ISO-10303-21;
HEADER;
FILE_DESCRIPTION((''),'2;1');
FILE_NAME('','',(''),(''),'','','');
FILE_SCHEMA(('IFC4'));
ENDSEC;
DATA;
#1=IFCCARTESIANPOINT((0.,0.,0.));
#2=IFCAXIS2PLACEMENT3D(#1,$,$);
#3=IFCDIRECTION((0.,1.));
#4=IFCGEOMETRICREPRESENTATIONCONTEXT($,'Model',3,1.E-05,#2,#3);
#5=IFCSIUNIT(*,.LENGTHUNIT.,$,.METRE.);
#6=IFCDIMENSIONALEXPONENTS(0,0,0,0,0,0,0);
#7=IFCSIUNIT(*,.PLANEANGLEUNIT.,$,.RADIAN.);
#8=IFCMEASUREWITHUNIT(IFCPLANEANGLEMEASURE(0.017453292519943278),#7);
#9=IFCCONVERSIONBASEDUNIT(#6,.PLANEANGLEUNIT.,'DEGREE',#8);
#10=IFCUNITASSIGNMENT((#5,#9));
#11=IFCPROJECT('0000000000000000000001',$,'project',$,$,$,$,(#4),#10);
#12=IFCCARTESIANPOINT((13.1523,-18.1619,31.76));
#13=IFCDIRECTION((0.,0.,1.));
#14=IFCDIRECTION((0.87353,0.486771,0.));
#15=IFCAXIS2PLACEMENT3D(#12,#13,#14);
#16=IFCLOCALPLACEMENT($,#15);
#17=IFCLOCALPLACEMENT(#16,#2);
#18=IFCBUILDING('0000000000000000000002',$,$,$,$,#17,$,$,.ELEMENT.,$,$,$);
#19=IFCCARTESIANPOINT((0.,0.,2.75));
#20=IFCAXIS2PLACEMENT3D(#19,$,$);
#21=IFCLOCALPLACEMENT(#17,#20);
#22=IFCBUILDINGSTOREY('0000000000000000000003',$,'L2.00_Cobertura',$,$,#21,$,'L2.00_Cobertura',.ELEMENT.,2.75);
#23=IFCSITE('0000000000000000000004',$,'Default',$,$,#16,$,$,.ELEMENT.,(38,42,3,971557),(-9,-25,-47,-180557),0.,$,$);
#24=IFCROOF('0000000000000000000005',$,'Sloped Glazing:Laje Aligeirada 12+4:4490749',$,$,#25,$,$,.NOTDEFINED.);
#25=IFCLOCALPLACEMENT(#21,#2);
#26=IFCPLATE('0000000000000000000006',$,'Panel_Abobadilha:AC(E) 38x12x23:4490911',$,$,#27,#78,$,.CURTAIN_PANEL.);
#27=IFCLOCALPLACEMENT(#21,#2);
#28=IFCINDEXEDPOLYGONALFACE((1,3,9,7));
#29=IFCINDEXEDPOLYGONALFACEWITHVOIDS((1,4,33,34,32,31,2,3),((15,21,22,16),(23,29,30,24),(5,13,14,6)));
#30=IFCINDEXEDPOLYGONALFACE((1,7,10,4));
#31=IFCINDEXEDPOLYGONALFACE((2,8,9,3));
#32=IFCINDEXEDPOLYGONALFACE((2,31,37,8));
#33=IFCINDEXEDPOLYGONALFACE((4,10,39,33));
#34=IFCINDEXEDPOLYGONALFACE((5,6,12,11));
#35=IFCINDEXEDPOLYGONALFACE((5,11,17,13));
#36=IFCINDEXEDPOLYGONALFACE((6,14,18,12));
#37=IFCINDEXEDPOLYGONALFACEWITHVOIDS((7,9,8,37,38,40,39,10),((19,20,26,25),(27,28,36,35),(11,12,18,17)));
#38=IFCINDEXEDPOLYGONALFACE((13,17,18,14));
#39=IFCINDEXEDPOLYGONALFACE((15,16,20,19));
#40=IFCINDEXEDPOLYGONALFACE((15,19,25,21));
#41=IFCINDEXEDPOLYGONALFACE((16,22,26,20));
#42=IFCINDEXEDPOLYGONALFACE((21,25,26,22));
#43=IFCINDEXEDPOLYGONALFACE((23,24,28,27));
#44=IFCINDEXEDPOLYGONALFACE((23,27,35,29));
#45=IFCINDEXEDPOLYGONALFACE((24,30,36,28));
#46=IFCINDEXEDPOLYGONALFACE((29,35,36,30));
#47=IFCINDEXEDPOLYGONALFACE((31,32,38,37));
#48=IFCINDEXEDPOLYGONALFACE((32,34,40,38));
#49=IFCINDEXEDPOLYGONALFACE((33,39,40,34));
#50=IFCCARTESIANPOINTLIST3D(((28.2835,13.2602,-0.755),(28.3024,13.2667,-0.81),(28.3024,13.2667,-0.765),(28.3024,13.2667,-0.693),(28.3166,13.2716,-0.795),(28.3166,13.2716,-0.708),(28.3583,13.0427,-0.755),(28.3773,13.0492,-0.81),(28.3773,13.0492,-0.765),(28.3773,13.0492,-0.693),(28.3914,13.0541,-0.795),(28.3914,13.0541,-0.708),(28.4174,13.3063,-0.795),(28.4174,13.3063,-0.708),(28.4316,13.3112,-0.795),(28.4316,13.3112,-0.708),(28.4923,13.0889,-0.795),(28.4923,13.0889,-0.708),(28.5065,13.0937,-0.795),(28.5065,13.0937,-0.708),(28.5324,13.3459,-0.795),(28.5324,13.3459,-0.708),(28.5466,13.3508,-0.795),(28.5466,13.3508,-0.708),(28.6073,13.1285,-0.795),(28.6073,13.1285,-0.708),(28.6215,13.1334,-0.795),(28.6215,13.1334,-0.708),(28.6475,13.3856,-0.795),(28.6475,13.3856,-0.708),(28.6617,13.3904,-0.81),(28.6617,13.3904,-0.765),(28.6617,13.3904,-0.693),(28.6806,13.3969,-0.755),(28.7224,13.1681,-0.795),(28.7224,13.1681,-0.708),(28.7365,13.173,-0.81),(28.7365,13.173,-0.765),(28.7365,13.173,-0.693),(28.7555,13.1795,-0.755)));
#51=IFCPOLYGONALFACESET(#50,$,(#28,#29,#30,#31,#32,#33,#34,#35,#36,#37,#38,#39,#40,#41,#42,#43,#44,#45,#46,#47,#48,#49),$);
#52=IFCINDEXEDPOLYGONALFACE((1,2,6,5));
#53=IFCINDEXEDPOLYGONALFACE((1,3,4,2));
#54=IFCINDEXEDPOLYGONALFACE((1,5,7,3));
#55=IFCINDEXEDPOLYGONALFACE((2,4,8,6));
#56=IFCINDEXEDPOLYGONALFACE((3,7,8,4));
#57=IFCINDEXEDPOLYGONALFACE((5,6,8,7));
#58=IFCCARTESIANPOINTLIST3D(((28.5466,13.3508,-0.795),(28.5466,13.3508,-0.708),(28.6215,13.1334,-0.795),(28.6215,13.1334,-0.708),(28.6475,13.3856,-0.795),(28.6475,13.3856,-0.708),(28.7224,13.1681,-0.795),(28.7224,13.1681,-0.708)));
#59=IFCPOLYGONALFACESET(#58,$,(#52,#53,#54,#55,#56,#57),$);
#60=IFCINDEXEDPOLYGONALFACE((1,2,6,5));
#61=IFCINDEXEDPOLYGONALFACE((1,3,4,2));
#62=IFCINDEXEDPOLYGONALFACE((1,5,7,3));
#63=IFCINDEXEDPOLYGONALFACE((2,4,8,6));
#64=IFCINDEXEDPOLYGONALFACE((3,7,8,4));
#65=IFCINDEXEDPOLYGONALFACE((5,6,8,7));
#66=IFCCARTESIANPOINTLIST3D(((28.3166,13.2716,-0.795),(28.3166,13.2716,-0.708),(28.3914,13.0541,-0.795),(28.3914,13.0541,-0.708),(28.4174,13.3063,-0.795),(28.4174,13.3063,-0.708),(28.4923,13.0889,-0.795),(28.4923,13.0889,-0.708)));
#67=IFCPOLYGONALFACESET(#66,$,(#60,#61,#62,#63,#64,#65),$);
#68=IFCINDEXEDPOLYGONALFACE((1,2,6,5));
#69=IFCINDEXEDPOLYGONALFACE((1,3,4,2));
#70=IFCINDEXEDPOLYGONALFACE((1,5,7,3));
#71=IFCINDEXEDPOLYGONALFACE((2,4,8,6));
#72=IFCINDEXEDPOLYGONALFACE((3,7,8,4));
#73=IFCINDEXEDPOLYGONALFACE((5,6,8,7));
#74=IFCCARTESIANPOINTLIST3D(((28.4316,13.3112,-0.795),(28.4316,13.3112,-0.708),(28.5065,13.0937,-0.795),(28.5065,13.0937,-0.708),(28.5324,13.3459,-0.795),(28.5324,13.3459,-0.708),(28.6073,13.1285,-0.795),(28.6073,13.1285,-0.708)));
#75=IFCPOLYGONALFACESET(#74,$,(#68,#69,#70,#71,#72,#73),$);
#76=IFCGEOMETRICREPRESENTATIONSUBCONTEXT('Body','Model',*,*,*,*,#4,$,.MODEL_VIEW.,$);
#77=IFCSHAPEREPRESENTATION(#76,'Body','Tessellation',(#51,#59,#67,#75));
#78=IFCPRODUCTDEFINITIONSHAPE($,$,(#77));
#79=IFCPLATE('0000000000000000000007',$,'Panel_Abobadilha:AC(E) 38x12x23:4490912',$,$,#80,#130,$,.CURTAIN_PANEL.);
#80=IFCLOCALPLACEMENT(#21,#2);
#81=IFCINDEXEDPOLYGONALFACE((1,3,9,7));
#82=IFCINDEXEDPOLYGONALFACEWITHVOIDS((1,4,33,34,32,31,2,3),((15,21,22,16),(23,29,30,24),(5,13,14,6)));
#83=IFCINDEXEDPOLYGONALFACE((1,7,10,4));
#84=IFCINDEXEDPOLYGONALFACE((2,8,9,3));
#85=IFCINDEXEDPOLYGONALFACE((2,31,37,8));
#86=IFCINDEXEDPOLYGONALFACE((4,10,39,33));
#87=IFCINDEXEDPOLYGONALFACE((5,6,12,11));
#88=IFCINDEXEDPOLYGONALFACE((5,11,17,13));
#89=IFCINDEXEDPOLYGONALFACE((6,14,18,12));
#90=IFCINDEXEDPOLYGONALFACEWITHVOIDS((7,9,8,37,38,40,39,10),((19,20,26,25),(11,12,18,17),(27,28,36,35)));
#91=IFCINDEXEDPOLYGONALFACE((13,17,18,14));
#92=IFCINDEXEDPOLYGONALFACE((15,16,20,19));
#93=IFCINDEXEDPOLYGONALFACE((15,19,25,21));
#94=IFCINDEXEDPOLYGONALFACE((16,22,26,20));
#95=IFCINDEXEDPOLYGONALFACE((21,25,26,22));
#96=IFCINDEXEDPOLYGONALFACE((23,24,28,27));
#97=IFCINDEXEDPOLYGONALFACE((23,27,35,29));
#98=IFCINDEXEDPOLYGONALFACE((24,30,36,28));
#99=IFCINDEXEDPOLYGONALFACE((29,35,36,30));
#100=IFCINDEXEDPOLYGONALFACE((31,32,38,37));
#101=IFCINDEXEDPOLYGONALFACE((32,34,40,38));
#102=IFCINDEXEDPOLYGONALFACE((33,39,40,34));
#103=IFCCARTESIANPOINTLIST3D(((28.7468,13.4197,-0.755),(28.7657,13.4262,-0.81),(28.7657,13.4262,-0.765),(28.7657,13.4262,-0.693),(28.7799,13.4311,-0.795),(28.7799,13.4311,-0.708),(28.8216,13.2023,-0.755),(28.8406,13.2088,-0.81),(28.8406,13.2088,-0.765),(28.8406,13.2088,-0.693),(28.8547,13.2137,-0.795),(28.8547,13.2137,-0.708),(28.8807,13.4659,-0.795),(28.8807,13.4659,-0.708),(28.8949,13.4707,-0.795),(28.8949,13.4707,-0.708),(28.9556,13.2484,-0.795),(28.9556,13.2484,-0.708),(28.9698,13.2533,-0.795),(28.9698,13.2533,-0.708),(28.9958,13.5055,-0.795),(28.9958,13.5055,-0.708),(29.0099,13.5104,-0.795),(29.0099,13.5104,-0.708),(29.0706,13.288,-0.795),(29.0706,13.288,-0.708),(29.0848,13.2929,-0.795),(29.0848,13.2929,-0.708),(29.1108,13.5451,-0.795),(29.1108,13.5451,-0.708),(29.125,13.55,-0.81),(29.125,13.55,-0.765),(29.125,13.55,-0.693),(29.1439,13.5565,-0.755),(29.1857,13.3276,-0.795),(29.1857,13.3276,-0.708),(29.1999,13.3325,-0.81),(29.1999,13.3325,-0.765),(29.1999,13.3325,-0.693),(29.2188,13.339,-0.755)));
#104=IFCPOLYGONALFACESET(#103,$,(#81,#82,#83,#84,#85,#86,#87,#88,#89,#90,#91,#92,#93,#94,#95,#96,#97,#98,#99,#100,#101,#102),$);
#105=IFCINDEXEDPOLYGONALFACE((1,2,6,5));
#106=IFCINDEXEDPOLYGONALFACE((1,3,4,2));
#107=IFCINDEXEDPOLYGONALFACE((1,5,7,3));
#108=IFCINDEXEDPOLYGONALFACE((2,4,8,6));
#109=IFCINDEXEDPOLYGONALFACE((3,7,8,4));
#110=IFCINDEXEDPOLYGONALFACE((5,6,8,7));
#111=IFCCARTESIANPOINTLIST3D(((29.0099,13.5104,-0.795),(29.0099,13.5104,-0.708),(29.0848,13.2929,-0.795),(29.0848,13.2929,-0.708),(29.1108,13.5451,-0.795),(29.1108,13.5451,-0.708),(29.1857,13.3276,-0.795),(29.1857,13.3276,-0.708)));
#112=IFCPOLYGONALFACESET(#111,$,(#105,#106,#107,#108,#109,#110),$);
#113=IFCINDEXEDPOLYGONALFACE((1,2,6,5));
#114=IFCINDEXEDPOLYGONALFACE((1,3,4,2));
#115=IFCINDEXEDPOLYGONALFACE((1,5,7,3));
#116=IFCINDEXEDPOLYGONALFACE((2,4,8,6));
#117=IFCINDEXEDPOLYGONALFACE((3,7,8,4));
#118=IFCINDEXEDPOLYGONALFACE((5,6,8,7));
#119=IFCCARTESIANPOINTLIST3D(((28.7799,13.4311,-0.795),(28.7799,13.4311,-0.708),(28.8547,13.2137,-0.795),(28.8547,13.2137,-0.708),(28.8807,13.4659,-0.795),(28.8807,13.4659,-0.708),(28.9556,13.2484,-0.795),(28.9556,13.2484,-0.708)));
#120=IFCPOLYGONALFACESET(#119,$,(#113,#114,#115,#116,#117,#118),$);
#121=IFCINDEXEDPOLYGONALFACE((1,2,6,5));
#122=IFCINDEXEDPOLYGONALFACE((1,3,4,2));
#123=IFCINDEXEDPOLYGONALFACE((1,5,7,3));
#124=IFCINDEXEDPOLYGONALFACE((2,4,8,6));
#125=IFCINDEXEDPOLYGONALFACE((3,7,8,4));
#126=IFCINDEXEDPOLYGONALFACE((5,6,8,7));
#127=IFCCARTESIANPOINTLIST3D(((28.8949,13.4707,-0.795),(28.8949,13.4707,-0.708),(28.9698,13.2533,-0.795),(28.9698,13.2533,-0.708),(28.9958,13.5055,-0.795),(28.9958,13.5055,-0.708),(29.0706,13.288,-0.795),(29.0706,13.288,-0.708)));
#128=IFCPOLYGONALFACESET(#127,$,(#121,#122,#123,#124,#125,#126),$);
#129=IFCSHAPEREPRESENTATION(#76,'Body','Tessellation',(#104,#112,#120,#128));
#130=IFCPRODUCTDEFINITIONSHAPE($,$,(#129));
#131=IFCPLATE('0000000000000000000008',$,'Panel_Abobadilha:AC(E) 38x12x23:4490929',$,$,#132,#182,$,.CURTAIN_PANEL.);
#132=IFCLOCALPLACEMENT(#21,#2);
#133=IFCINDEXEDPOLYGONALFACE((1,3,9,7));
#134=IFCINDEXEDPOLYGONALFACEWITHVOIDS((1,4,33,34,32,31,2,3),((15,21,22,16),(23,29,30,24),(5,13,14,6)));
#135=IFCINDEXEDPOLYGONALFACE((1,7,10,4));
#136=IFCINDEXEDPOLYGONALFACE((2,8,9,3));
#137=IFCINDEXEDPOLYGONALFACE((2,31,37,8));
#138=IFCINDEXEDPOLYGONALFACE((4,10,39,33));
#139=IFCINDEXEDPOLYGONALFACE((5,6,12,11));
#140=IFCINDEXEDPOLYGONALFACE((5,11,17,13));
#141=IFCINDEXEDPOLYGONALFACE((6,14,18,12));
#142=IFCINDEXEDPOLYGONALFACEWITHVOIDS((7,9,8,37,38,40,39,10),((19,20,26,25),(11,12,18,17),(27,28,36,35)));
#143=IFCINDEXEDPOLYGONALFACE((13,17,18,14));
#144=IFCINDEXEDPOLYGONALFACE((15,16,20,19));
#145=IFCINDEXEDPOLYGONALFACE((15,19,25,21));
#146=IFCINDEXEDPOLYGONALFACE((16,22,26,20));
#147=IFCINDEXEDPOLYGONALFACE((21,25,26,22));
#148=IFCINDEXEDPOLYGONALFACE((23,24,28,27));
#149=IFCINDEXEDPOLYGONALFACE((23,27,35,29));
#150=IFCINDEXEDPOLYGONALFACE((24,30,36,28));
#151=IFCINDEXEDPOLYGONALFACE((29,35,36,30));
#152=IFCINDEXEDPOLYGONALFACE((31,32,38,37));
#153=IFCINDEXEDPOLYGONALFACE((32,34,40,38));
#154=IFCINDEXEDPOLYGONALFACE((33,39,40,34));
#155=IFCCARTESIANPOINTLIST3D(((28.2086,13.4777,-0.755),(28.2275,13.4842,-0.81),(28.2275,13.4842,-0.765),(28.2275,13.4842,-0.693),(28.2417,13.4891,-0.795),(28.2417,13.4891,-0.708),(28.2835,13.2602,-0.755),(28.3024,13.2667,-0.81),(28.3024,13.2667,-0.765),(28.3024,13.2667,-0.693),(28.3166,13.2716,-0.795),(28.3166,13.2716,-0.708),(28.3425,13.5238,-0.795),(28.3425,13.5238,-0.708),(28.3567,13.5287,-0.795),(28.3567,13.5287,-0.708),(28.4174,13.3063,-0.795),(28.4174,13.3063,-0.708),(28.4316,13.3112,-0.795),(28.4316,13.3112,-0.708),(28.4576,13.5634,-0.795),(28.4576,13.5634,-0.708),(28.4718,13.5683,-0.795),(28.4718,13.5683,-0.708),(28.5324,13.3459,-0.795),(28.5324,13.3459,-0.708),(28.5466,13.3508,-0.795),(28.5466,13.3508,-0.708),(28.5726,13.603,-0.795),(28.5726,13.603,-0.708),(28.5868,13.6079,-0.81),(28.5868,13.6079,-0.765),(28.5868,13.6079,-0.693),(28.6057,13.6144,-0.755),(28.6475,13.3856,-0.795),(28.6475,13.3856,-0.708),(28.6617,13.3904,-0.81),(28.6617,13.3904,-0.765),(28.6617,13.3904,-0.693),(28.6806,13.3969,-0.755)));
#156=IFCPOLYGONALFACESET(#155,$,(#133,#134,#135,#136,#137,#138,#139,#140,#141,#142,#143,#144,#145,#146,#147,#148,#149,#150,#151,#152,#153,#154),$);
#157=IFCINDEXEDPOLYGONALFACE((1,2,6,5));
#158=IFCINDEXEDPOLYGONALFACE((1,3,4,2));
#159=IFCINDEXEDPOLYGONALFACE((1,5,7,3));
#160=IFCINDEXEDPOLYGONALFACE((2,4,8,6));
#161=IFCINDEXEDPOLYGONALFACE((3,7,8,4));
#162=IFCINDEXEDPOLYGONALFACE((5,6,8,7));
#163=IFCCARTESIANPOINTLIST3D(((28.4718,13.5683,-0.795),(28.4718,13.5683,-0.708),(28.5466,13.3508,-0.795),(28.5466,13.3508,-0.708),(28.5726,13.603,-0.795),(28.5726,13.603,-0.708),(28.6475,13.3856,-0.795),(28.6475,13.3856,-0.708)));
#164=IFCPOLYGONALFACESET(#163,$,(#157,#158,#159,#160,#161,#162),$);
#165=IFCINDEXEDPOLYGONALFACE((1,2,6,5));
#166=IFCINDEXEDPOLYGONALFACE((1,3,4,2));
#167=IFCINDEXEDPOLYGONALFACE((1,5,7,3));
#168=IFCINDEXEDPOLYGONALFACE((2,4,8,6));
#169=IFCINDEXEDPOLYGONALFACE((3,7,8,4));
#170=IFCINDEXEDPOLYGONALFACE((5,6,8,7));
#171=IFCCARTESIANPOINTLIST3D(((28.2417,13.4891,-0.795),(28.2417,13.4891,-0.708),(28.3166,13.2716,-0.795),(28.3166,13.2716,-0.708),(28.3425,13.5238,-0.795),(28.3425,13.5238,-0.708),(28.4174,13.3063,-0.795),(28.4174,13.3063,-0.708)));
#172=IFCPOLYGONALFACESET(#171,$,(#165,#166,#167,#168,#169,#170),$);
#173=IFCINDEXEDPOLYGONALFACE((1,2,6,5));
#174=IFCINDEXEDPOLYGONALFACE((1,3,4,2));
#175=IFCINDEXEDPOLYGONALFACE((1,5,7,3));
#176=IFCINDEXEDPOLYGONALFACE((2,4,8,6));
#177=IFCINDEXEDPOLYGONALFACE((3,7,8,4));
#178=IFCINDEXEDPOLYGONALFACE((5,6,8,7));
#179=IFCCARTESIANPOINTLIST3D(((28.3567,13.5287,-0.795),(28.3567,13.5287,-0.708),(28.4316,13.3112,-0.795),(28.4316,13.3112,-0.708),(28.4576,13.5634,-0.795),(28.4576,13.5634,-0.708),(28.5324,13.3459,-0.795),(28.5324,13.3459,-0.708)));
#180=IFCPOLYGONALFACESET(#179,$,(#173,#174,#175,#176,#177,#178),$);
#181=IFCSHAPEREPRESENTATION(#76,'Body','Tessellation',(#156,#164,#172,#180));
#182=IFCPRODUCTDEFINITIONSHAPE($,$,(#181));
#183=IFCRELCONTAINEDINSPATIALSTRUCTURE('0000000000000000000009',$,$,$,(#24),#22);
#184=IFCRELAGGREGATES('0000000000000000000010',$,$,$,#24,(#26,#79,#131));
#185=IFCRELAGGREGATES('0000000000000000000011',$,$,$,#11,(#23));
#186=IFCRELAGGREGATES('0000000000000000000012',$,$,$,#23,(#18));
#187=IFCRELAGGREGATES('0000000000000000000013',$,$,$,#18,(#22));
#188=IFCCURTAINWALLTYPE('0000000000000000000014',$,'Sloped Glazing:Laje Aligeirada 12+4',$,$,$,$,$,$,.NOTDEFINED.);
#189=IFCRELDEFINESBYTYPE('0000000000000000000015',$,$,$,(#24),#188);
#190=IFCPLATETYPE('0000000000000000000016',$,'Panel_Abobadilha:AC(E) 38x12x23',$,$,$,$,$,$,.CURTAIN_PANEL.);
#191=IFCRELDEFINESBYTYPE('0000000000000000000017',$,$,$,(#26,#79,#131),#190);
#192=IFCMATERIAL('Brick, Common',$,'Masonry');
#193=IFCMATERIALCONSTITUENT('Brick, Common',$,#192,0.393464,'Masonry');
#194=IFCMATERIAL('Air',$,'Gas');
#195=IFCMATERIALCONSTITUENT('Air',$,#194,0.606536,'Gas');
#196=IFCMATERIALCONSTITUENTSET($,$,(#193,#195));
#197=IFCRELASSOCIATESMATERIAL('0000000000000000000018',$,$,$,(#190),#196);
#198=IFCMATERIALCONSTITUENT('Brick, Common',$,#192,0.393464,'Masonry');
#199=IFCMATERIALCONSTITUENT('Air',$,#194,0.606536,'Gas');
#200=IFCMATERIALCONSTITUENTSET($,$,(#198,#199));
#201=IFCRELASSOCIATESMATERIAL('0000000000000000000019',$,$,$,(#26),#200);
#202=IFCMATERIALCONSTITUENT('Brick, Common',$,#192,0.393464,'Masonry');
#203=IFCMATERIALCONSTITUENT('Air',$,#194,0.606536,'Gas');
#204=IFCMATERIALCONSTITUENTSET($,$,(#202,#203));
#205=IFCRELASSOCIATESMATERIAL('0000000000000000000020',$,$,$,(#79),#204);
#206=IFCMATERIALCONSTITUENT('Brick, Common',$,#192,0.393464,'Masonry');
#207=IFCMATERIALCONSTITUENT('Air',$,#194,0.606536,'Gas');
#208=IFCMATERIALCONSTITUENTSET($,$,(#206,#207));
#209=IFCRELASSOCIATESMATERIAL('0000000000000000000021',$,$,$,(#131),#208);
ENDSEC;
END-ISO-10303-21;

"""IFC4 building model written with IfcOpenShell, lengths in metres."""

from ifc_helpers import new_model, entity, si_unit, converted_unit, direction, frame, origin, place, context, subcontext, project, spatial, indexed_curve, outline, extrude, source, transform, mapped, material, constituent, constituent_set, type_object, type_shapes, element, aggregate, save


model = new_model("IFC4")

# Units and contexts
model_context = context("Model", 3, precision=1e-05, world=origin(), true_north=direction((0.0, 1.0)))
body_context = subcontext(model_context, "Body", "Model", "MODEL_VIEW")
ifc_project = project(units=[si_unit("LENGTHUNIT", "METRE"), converted_unit("PLANEANGLEUNIT", "DEGREE", entity("IfcPlaneAngleMeasure", 0.017453292519943278), si_unit("PLANEANGLEUNIT", "RADIAN"), dimensions=[0, 0, 0, 0, 0, 0, 0])], contexts=[model_context])

# Site, building, storey
site_placement = place(None, frame((13.1523, -18.1619, 31.76), z_axis=(0.0, 0.0, 1.0), x_axis=(0.87353, 0.486771, 0.0)))
site = spatial("IfcSite", under=ifc_project, at=site_placement, Name="Default", CompositionType="ELEMENT", RefLatitude=(38, 42, 3, 971557), RefLongitude=(-9, -25, -47, -180557), RefElevation=0.0)
building_placement = place(site_placement, origin())
building = spatial("IfcBuilding", under=site, at=building_placement, CompositionType="ELEMENT")
storey_placement = place(building_placement, frame((0.0, 0.0, 2.75)))
storey = spatial("IfcBuildingStorey", under=building, at=storey_placement, Name="L2.00_Cobertura", LongName="L2.00_Cobertura", CompositionType="ELEMENT", Elevation=2.75)

# Roof, plates
curtain_wall_type = type_object("IfcCurtainWallType", Name="Sloped Glazing:Laje Aligeirada 12+4", PredefinedType="NOTDEFINED")
roof_placement = place(storey_placement, frame((0.0, 0.0, -2.75)))
roof = element("IfcRoof", 1, at=roof_placement, inside=storey, type_object=curtain_wall_type, Name="Sloped Glazing:Laje Aligeirada 12+4:4490749", PredefinedType="NOTDEFINED")
ifc_material_1 = material(Name="Brick, Common", Category="Masonry")
ifc_material_2 = material(Name="Air", Category="Gas")
ifc_constituent_1 = constituent(ifc_material_1, Name="Brick, Common", Category="Masonry", fraction=0.393464)
ifc_constituent_2 = constituent(ifc_material_2, Name="Air", Category="Gas", fraction=0.606536)
ifc_constituent_set_1 = constituent_set(constituents=[ifc_constituent_1, ifc_constituent_2])
plate_type_1 = type_object("IfcPlateType", Name="Panel_Abobadilha:AC(E) 38x12x23", PredefinedType="CURTAIN_PANEL", material=ifc_constituent_set_1)
shared_shape_1 = source(origin(), body_context, "Body", "SweptSolid", [
    extrude(outline(indexed_curve([(-0.19, -0.0543), (0.19, -0.0543), (0.19, -0.0093), (0.21, 0.0007), (0.19, 0.0628), (-0.19, 0.0628), (-0.21, 0.0007), (-0.19, -0.0093), (-0.19, -0.0543)], self_intersect=False), holes=[indexed_curve([(-0.0683, 0.0477), (-0.0683, -0.0393), (-0.175, -0.0393), (-0.175, 0.0477), (-0.0683, 0.0477)], self_intersect=False), indexed_curve([(0.0533, 0.0477), (0.0533, -0.0393), (-0.0533, -0.0393), (-0.0533, 0.0477), (0.0533, 0.0477)], self_intersect=False), indexed_curve([(0.175, 0.0477), (0.175, -0.0393), (0.0683, -0.0393), (0.0683, 0.0477), (0.175, 0.0477)], self_intersect=False)]), frame((0.0, 0.0543, 0.0)), (0.0, 0.0, 1.0), 0.23),
    extrude(outline(indexed_curve([(-0.0533, -0.0435), (0.0533, -0.0435), (0.0533, 0.0435), (-0.0533, 0.0435), (-0.0533, -0.0435)], self_intersect=False)), frame((0.1217, 0.0585, 0.0), z_axis=(0.0, 0.0, 1.0), x_axis=(-1.0, 0.0, 0.0)), (0.0, 0.0, 1.0), 0.23),
    extrude(outline(indexed_curve([(-0.0533, -0.0435), (0.0533, -0.0435), (0.0533, 0.0435), (-0.0533, 0.0435), (-0.0533, -0.0435)], self_intersect=False)), frame((-0.1217, 0.0585, 0.0), z_axis=(0.0, 0.0, 1.0), x_axis=(-1.0, 0.0, 0.0)), (0.0, 0.0, 1.0), 0.23),
    extrude(outline(indexed_curve([(-0.0533, -0.0435), (0.0533, -0.0435), (0.0533, 0.0435), (-0.0533, 0.0435), (-0.0533, -0.0435)], self_intersect=False)), frame((0.0, 0.0585, 0.0), z_axis=(0.0, 0.0, 1.0), x_axis=(-1.0, 0.0, 0.0)), (0.0, 0.0, 1.0), 0.23),
])
type_shapes(plate_type_1, [shared_shape_1])
ifc_constituent_3 = constituent(ifc_material_1, Name="Brick, Common", Category="Masonry", fraction=0.393464)
ifc_constituent_4 = constituent(ifc_material_2, Name="Air", Category="Gas", fraction=0.606536)
ifc_constituent_set_2 = constituent_set(constituents=[ifc_constituent_3, ifc_constituent_4])
plate_1_placement = place(roof_placement, frame((28.482, 13.3286, 1.94), z_axis=(0.325568, -0.945519, 0.0), x_axis=(0.945519, 0.325568, 0.0)))
plate_1 = element("IfcPlate", 2, at=plate_1_placement, type_object=plate_type_1, material=ifc_constituent_set_2, Name="Panel_Abobadilha:AC(E) 38x12x23:4490911", PredefinedType="CURTAIN_PANEL", context=body_context, shape_type="MappedRepresentation", body=[
    mapped(shared_shape_1, transform((0.0, 0.0, 0.0), scale=1.0)),
])
ifc_constituent_5 = constituent(ifc_material_1, Name="Brick, Common", Category="Masonry", fraction=0.393464)
ifc_constituent_6 = constituent(ifc_material_2, Name="Air", Category="Gas", fraction=0.606536)
ifc_constituent_set_3 = constituent_set(constituents=[ifc_constituent_5, ifc_constituent_6])
plate_2_placement = place(roof_placement, frame((28.9453, 13.4881, 1.94), z_axis=(0.325568, -0.945519, 0.0), x_axis=(0.945519, 0.325568, 0.0)))
plate_2 = element("IfcPlate", 3, at=plate_2_placement, type_object=plate_type_1, material=ifc_constituent_set_3, Name="Panel_Abobadilha:AC(E) 38x12x23:4490912", PredefinedType="CURTAIN_PANEL", context=body_context, shape_type="MappedRepresentation", body=[
    mapped(shared_shape_1, transform((0.0, 0.0, 0.0), scale=1.0)),
])
ifc_constituent_7 = constituent(ifc_material_1, Name="Brick, Common", Category="Masonry", fraction=0.393464)
ifc_constituent_8 = constituent(ifc_material_2, Name="Air", Category="Gas", fraction=0.606536)
ifc_constituent_set_4 = constituent_set(constituents=[ifc_constituent_7, ifc_constituent_8])
plate_3_placement = place(roof_placement, frame((28.4071, 13.546, 1.94), z_axis=(0.325568, -0.945519, 0.0), x_axis=(0.945519, 0.325568, 0.0)))
plate_3 = element("IfcPlate", 4, at=plate_3_placement, type_object=plate_type_1, material=ifc_constituent_set_4, Name="Panel_Abobadilha:AC(E) 38x12x23:4490929", PredefinedType="CURTAIN_PANEL", context=body_context, shape_type="MappedRepresentation", body=[
    mapped(shared_shape_1, transform((0.0, 0.0, 0.0), scale=1.0)),
])
aggregate(roof, [plate_1, plate_2, plate_3])

save(model, "model.ifc")
